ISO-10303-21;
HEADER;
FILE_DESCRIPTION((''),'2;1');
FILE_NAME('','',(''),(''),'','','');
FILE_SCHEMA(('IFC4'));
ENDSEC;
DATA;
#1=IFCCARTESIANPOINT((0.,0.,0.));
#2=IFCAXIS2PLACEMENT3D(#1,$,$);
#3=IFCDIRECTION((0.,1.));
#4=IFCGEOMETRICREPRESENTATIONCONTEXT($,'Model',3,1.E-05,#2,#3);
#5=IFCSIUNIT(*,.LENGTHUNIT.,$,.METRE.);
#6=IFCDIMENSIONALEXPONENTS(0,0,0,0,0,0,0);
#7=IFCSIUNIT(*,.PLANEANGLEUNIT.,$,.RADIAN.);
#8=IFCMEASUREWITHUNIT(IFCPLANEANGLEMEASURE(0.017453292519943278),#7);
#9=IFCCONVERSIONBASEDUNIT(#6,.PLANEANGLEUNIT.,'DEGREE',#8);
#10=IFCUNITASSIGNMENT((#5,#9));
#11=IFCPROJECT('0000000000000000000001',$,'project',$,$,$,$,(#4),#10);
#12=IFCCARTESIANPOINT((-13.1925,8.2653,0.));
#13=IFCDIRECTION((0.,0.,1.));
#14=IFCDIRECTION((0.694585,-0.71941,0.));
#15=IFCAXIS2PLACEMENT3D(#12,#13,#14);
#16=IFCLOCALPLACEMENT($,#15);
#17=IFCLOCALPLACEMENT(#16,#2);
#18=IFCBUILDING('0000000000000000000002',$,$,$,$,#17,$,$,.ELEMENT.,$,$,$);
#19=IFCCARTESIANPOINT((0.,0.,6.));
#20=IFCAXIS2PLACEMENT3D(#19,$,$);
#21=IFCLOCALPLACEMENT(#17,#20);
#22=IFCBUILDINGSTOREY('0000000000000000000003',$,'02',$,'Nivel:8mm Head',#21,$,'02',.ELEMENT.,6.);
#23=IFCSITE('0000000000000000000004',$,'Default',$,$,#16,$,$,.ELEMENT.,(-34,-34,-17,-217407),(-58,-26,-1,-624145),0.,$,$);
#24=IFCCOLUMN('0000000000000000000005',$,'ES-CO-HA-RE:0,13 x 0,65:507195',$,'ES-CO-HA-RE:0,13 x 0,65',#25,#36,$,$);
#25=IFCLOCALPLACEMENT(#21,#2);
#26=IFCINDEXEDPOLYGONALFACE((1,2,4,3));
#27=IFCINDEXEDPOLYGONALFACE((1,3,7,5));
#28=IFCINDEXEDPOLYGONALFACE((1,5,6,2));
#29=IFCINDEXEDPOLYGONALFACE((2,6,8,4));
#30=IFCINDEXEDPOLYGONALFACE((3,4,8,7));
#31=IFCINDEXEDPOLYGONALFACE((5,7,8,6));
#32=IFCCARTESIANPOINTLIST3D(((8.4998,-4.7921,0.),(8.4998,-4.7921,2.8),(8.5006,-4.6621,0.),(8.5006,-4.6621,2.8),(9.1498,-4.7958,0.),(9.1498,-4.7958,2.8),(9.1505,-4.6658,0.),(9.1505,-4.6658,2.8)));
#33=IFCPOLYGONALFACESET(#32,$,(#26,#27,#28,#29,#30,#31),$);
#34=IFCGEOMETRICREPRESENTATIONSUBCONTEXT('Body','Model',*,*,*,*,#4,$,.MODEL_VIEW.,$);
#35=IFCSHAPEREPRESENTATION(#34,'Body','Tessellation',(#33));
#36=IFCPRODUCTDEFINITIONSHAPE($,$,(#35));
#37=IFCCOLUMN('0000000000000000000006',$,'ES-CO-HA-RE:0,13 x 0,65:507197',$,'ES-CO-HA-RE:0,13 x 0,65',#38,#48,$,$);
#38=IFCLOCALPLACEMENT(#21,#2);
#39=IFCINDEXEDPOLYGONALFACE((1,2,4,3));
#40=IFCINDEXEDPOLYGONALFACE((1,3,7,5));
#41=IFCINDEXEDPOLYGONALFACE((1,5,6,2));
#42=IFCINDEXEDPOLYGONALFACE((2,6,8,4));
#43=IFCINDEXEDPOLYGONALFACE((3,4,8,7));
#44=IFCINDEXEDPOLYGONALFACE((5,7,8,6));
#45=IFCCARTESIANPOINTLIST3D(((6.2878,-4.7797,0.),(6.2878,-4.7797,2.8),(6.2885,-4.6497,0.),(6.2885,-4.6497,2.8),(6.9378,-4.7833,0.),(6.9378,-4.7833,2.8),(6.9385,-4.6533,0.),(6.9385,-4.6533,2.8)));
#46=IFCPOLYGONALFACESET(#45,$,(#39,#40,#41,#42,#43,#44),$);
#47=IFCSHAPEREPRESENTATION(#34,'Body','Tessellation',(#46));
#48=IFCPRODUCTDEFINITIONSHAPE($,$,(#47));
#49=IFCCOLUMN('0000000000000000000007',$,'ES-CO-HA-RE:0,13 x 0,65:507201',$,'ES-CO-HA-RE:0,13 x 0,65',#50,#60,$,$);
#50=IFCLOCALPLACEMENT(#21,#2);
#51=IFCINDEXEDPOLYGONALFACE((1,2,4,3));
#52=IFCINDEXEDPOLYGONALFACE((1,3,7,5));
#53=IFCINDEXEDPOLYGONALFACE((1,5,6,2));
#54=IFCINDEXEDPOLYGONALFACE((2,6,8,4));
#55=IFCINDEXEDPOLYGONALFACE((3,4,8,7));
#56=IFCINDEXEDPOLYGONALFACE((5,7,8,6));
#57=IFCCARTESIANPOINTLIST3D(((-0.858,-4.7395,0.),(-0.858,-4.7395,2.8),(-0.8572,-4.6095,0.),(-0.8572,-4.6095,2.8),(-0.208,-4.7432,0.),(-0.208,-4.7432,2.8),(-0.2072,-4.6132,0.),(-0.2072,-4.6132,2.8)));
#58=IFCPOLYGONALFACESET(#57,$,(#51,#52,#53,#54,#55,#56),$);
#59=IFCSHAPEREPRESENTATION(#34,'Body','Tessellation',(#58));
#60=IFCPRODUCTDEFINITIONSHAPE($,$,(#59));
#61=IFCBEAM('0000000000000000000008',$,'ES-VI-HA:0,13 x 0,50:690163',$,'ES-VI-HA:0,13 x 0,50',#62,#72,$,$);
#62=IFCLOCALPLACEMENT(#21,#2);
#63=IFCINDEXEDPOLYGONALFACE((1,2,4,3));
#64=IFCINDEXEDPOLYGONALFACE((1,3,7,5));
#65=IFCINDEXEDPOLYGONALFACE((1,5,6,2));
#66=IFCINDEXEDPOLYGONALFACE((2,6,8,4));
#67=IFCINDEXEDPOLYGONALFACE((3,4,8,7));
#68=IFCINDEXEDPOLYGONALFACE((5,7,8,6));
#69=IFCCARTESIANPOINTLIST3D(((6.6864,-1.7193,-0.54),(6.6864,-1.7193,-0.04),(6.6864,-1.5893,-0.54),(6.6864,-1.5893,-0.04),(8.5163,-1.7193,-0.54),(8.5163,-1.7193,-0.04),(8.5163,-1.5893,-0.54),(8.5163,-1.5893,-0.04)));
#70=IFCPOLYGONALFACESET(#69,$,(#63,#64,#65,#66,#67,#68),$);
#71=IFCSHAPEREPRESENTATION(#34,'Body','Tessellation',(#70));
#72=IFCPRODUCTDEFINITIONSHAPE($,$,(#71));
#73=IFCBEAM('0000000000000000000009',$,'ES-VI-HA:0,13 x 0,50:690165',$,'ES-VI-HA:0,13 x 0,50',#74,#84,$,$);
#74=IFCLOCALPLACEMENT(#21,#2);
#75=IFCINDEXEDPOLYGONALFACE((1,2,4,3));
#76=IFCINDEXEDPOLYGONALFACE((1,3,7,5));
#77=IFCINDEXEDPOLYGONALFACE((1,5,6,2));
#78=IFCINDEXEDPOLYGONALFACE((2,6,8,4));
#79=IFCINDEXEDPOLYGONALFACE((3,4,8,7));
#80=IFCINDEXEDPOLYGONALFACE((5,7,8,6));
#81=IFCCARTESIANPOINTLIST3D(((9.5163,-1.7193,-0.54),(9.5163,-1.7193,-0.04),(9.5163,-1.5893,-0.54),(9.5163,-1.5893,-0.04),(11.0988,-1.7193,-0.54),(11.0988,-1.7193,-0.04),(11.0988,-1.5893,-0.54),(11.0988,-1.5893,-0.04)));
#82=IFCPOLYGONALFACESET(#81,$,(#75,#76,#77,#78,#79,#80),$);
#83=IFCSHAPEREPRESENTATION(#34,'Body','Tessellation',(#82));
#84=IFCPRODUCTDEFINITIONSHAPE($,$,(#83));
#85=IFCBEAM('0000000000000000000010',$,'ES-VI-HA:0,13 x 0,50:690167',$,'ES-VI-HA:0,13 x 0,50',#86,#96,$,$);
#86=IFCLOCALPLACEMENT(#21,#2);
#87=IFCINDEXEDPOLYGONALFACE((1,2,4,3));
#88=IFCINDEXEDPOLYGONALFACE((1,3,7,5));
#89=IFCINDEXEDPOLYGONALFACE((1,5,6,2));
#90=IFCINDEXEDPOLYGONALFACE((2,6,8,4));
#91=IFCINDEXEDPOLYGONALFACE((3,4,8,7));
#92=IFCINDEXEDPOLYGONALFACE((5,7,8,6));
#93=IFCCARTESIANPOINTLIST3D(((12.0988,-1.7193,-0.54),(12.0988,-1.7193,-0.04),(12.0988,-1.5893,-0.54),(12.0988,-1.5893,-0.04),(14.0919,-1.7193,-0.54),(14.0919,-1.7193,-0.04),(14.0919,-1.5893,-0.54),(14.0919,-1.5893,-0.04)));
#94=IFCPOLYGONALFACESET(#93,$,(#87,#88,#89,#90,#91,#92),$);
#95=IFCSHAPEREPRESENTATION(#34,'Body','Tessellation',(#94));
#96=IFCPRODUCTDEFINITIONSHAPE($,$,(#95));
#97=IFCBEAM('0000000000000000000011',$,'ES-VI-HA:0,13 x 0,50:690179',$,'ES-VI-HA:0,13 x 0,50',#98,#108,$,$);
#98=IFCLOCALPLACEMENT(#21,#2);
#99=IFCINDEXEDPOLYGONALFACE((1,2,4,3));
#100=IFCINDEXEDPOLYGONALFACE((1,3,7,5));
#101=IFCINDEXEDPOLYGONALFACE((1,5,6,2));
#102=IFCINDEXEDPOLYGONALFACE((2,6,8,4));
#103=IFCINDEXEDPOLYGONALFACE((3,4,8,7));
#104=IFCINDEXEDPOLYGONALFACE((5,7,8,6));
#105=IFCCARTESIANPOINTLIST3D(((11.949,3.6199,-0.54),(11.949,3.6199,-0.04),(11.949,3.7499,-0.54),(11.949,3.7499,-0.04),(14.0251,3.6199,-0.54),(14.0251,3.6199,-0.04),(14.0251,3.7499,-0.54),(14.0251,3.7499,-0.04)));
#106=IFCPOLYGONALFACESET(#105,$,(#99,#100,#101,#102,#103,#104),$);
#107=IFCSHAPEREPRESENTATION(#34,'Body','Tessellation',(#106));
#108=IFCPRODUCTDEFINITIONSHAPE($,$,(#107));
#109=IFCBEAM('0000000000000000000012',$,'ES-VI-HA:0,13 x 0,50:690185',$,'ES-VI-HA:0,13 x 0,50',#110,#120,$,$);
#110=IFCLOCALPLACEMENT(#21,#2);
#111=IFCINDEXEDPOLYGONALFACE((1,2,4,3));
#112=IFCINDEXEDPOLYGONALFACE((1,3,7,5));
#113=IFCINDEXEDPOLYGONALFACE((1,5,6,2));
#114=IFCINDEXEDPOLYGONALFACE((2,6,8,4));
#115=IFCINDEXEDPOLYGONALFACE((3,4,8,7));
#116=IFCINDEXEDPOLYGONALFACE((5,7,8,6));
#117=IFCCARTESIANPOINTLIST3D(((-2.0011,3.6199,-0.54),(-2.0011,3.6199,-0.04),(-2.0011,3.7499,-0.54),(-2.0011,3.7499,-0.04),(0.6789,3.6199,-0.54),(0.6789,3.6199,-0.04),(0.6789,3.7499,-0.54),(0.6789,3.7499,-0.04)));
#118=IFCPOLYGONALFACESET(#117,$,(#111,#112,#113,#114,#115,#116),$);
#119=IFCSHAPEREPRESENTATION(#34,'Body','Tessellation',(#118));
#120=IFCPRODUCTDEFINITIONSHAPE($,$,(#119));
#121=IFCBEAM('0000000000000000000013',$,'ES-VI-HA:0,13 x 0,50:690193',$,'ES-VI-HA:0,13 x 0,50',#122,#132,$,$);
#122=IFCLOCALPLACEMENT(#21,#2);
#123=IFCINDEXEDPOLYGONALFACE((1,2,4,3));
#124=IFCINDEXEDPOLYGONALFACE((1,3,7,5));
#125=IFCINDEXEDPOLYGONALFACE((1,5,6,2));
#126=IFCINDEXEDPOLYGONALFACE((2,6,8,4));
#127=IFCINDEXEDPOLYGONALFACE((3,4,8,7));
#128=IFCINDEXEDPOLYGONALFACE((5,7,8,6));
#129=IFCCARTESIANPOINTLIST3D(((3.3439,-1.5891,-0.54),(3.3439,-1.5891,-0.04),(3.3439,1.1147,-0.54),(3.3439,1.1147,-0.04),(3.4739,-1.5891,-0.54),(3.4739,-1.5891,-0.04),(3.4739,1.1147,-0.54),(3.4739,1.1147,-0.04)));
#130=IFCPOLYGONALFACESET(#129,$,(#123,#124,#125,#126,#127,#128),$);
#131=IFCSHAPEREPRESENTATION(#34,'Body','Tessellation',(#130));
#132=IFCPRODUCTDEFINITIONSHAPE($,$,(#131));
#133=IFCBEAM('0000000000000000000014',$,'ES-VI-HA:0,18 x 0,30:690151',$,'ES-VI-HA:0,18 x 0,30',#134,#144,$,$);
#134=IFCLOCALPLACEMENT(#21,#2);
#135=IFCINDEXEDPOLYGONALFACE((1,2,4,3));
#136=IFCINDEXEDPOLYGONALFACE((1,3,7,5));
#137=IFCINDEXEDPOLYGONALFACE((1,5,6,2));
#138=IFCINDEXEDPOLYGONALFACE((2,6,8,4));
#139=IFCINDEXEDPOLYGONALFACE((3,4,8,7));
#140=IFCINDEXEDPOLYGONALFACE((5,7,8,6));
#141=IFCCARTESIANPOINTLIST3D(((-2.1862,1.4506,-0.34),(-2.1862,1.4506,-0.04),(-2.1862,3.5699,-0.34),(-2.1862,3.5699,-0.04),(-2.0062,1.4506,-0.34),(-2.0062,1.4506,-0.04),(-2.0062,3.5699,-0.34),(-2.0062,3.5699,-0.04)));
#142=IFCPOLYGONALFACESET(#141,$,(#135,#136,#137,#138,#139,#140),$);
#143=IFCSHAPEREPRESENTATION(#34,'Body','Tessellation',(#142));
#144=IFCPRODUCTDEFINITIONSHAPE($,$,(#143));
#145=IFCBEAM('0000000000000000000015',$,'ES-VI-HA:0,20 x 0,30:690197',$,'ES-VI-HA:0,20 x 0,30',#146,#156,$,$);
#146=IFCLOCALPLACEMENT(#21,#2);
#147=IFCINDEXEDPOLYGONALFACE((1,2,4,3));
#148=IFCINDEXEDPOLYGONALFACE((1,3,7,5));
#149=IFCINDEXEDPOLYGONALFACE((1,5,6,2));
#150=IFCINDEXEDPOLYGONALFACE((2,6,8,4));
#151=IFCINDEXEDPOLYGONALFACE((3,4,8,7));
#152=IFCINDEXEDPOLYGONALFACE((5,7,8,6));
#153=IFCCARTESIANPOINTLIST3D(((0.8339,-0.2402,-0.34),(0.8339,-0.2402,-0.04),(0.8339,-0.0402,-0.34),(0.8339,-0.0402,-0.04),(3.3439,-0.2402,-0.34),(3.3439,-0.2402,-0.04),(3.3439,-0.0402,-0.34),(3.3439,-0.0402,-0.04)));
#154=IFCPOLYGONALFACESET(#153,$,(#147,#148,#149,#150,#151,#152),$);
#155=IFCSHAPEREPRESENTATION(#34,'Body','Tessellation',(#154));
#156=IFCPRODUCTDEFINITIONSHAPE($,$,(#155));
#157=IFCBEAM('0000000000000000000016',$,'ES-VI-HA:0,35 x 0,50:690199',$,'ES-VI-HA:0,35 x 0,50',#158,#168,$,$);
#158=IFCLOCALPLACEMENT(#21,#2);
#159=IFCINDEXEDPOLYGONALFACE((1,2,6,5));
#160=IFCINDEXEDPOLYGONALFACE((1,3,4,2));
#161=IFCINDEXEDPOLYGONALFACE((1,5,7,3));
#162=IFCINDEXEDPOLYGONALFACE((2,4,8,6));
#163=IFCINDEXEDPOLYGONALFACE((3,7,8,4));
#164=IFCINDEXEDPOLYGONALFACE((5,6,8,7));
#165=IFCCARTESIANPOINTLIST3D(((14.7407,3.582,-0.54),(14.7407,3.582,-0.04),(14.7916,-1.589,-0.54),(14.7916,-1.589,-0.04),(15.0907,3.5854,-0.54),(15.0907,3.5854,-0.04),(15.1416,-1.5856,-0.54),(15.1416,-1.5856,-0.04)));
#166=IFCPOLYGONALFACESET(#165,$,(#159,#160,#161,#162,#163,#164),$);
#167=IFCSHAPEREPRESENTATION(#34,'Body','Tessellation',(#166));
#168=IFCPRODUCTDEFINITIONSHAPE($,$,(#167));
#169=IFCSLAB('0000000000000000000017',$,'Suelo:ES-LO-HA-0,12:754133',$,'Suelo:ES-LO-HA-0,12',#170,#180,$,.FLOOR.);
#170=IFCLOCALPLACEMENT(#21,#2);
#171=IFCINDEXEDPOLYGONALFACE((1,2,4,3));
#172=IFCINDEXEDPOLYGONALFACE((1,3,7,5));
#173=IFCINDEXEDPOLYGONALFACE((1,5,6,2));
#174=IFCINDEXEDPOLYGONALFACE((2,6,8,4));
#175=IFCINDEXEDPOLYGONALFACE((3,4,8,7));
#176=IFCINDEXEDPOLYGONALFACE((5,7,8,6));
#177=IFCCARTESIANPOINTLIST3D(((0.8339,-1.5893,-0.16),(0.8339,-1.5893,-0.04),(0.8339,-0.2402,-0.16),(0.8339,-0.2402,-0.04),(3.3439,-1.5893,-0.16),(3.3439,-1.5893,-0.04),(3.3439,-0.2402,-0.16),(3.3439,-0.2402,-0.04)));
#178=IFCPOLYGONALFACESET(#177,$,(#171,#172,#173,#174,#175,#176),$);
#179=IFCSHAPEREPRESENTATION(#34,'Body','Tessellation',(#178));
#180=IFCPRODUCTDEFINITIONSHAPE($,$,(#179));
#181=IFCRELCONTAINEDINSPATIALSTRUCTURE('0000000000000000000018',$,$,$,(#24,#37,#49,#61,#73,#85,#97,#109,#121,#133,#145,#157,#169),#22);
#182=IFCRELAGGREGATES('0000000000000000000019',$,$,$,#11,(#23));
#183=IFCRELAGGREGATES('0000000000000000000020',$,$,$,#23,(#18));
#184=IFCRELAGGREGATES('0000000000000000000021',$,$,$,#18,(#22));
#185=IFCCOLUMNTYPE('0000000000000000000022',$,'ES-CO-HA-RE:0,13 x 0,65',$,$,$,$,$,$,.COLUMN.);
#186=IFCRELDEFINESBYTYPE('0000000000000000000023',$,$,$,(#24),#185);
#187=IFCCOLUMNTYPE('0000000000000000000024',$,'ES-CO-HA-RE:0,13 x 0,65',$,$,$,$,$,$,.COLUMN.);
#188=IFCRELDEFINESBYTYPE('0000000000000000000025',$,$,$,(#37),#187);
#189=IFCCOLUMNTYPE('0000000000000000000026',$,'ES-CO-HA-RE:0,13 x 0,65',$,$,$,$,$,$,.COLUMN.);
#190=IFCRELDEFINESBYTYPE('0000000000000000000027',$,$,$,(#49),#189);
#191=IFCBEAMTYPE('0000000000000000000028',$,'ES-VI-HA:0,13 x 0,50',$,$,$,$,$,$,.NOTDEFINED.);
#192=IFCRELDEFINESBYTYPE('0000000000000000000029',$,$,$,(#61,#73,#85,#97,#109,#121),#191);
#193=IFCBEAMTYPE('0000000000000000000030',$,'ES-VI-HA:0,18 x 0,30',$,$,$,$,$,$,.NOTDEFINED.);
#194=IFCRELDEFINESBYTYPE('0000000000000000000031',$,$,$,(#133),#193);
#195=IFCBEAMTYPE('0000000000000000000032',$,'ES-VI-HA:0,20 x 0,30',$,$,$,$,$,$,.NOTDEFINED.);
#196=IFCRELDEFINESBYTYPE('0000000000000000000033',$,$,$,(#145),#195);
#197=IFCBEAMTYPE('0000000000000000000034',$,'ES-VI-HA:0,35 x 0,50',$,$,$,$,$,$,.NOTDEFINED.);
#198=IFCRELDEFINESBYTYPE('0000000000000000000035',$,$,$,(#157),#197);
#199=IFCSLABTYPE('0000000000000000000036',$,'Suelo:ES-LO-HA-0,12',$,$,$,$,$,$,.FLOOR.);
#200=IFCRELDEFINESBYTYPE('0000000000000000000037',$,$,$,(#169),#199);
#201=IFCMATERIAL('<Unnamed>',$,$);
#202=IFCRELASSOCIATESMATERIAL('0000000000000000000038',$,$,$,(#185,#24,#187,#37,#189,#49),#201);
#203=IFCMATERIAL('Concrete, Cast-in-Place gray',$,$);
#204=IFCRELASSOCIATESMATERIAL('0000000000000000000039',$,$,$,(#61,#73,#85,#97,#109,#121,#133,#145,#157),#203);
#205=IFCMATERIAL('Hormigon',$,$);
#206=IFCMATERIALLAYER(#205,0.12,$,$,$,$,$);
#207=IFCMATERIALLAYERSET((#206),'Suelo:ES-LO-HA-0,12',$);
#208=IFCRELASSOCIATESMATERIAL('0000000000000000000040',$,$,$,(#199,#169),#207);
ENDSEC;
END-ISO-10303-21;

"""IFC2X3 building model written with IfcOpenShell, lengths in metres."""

from ifc_helpers import new_model, entity, si_unit, converted_unit, direction, frame, frame_2d, origin, origin_2d_with_axis, place, context, subcontext, project, spatial, rectangle, extrude, source, transform, mapped, material, layer, layer_set, layer_usage, type_object, type_shapes, element, save


model = new_model("IFC2X3")

# Units and contexts
model_context = context("Model", 3, precision=1e-05, world=origin(), true_north=direction((0.0, 1.0)))
body_context = subcontext(model_context, "Body", "Model", "MODEL_VIEW")
ifc_project = project(units=[si_unit("LENGTHUNIT", "METRE"), converted_unit("PLANEANGLEUNIT", "DEGREE", entity("IfcPlaneAngleMeasure", 0.017453292519943278), si_unit("PLANEANGLEUNIT", "RADIAN"), dimensions=[0, 0, 0, 0, 0, 0, 0])], contexts=[model_context])

# Site, building, storey
site_placement = place(None, frame((-13.1925, 8.2653, 0.0), z_axis=(0.0, 0.0, 1.0), x_axis=(0.694585, -0.71941, 0.0)))
site = spatial("IfcSite", under=ifc_project, at=site_placement, Name="Default", CompositionType="ELEMENT", RefLatitude=(-34, -34, -17, -217407), RefLongitude=(-58, -26, -1, -624145), RefElevation=0.0)
building_placement = place(site_placement, origin())
building = spatial("IfcBuilding", under=site, at=building_placement, CompositionType="ELEMENT")
storey_placement = place(building_placement, frame((0.0, 0.0, 6.0)))
storey = spatial("IfcBuildingStorey", under=building, at=storey_placement, Name="02", ObjectType="Nivel:8mm Head", LongName="02", CompositionType="ELEMENT", Elevation=6.0)

# Columns
ifc_material_1 = material(Name="<Unnamed>")
column_type_1 = type_object("IfcColumnType", Name="ES-CO-HA-RE:0,13 x 0,65", PredefinedType="COLUMN", material=ifc_material_1)
shared_shape_1 = source(origin(), body_context, "Body", "SweptSolid", [
    extrude(rectangle(XDim=0.65, YDim=0.13, at=origin_2d_with_axis()), frame((8.8252, -4.7289, 6.0), z_axis=(0.0, 0.0, 1.0), x_axis=(-0.999984, 0.005619, 0.0)), (0.0, 0.0, 1.0), 2.8),
])
type_shapes(column_type_1, [shared_shape_1])
column_1_placement = place(storey_placement, frame((0.0, 0.0, -6.0)))
element("IfcColumn", 1, at=column_1_placement, inside=storey, type_object=column_type_1, material=ifc_material_1, Name="ES-CO-HA-RE:0,13 x 0,65:507195", ObjectType="ES-CO-HA-RE:0,13 x 0,65", context=body_context, shape_type="MappedRepresentation", body=[
    mapped(shared_shape_1, transform((0.0, 0.0, 0.0), scale=1.0)),
])
column_type_2 = type_object("IfcColumnType", Name="ES-CO-HA-RE:0,13 x 0,65", PredefinedType="COLUMN", material=ifc_material_1)
shared_shape_2 = source(origin(), body_context, "Body", "SweptSolid", [
    extrude(rectangle(XDim=0.65, YDim=0.13, at=frame_2d((0.0, 0.0), x_axis=(1.0, 0.0))), frame((6.6131, -4.7165, 6.0), z_axis=(0.0, 0.0, 1.0), x_axis=(-0.999984, 0.005619, 0.0)), (0.0, 0.0, 1.0), 2.8),
])
type_shapes(column_type_2, [shared_shape_2])
column_2_placement = place(storey_placement, frame((0.0, 0.0, -6.0)))
element("IfcColumn", 2, at=column_2_placement, inside=storey, type_object=column_type_2, material=ifc_material_1, Name="ES-CO-HA-RE:0,13 x 0,65:507197", ObjectType="ES-CO-HA-RE:0,13 x 0,65", context=body_context, shape_type="MappedRepresentation", body=[
    mapped(shared_shape_2, transform((0.0, 0.0, 0.0), scale=1.0)),
])
column_type_3 = type_object("IfcColumnType", Name="ES-CO-HA-RE:0,13 x 0,65", PredefinedType="COLUMN", material=ifc_material_1)
shared_shape_3 = source(origin(), body_context, "Body", "SweptSolid", [
    extrude(rectangle(XDim=0.65, YDim=0.13, at=frame_2d((0.0, 0.0), x_axis=(1.0, 0.0))), frame((-0.5326, -4.6764, 6.0), z_axis=(0.0, 0.0, 1.0), x_axis=(-0.999984, 0.005619, 0.0)), (0.0, 0.0, 1.0), 2.8),
])
type_shapes(column_type_3, [shared_shape_3])
column_3_placement = place(storey_placement, frame((0.0, 0.0, -6.0)))
element("IfcColumn", 3, at=column_3_placement, inside=storey, type_object=column_type_3, material=ifc_material_1, Name="ES-CO-HA-RE:0,13 x 0,65:507201", ObjectType="ES-CO-HA-RE:0,13 x 0,65", context=body_context, shape_type="MappedRepresentation", body=[
    mapped(shared_shape_3, transform((0.0, 0.0, 0.0), scale=1.0)),
])

# Beams
ifc_material_2 = material(Name="Concrete, Cast-in-Place gray")
beam_type_1 = type_object("IfcBeamType", Name="ES-VI-HA:0,13 x 0,50", PredefinedType="NOTDEFINED")
beam_1_placement = place(storey_placement, frame((5.7373, -1.6543, -0.04)))
element("IfcBeam", 4, at=beam_1_placement, inside=storey, type_object=beam_type_1, material=ifc_material_2, Name="ES-VI-HA:0,13 x 0,50:690163", ObjectType="ES-VI-HA:0,13 x 0,50", context=body_context, shape_type="SweptSolid", body=[
    extrude(rectangle(XDim=0.5, YDim=0.13, at=frame_2d((0.0, 0.0), x_axis=(1.0, 0.0))), frame((0.9491, 0.0, -0.25), z_axis=(1.0, 0.0, 0.0), x_axis=(0.0, 0.0, -1.0)), (0.0, 0.0, 1.0), 1.8299),
])
beam_2_placement = place(storey_placement, frame((8.3198, -1.6543, -0.04)))
element("IfcBeam", 5, at=beam_2_placement, inside=storey, type_object=beam_type_1, material=ifc_material_2, Name="ES-VI-HA:0,13 x 0,50:690165", ObjectType="ES-VI-HA:0,13 x 0,50", context=body_context, shape_type="SweptSolid", body=[
    extrude(rectangle(XDim=0.5, YDim=0.13, at=frame_2d((0.0, 0.0), x_axis=(1.0, 0.0))), frame((1.1965, 0.0, -0.25), z_axis=(1.0, 0.0, 0.0), x_axis=(0.0, 0.0, -1.0)), (0.0, 0.0, 1.0), 1.5825),
])
beam_3_placement = place(storey_placement, frame((11.3129, -1.6543, -0.04)))
element("IfcBeam", 6, at=beam_3_placement, inside=storey, type_object=beam_type_1, material=ifc_material_2, Name="ES-VI-HA:0,13 x 0,50:690167", ObjectType="ES-VI-HA:0,13 x 0,50", context=body_context, shape_type="SweptSolid", body=[
    extrude(rectangle(XDim=0.5, YDim=0.13, at=frame_2d((0.0, 0.0), x_axis=(1.0, 0.0))), frame((0.7858, 0.0, -0.25), z_axis=(1.0, 0.0, 0.0), x_axis=(0.0, 0.0, -1.0)), (0.0, 0.0, 1.0), 1.9932),
])
beam_4_placement = place(storey_placement, frame((11.624, 3.6849, -0.04)))
element("IfcBeam", 7, at=beam_4_placement, inside=storey, type_object=beam_type_1, material=ifc_material_2, Name="ES-VI-HA:0,13 x 0,50:690179", ObjectType="ES-VI-HA:0,13 x 0,50", context=body_context, shape_type="SweptSolid", body=[
    extrude(rectangle(XDim=0.5, YDim=0.13, at=frame_2d((0.0, 0.0), x_axis=(1.0, 0.0))), frame((0.325, 0.0, -0.25), z_axis=(1.0, 0.0, 0.0), x_axis=(0.0, 0.0, -1.0)), (0.0, 0.0, 1.0), 2.0761),
])
beam_5_placement = place(storey_placement, frame((-2.0011, 3.6849, -0.04)))
element("IfcBeam", 8, at=beam_5_placement, inside=storey, type_object=beam_type_1, material=ifc_material_2, Name="ES-VI-HA:0,13 x 0,50:690185", ObjectType="ES-VI-HA:0,13 x 0,50", context=body_context, shape_type="SweptSolid", body=[
    extrude(rectangle(XDim=0.5, YDim=0.13, at=frame_2d((0.0, 0.0), x_axis=(1.0, 0.0))), frame((0.0, 0.0, -0.25), z_axis=(1.0, 0.0, 0.0), x_axis=(0.0, 0.0, -1.0)), (0.0, 0.0, 1.0), 2.68),
])
beam_6_placement = place(storey_placement, frame((3.4089, -1.5891, -0.04), z_axis=(0.0, 0.0, 1.0), x_axis=(0.0, 1.0, 0.0)))
element("IfcBeam", 9, at=beam_6_placement, inside=storey, type_object=beam_type_1, material=ifc_material_2, Name="ES-VI-HA:0,13 x 0,50:690193", ObjectType="ES-VI-HA:0,13 x 0,50", context=body_context, shape_type="SweptSolid", body=[
    extrude(rectangle(XDim=0.5, YDim=0.13, at=origin_2d_with_axis()), frame((0.0, 0.0, -0.25), z_axis=(1.0, 0.0, 0.0), x_axis=(0.0, 0.0, -1.0)), (0.0, 0.0, 1.0), 2.7037),
])
beam_type_2 = type_object("IfcBeamType", Name="ES-VI-HA:0,18 x 0,30", PredefinedType="NOTDEFINED")
beam_7_placement = place(storey_placement, frame((-2.0962, 3.5699, -0.04), z_axis=(0.0, 0.0, 1.0), x_axis=(0.0, -1.0, 0.0)))
element("IfcBeam", 10, at=beam_7_placement, inside=storey, type_object=beam_type_2, material=ifc_material_2, Name="ES-VI-HA:0,18 x 0,30:690151", ObjectType="ES-VI-HA:0,18 x 0,30", context=body_context, shape_type="SweptSolid", body=[
    extrude(rectangle(XDim=0.3, YDim=0.18, at=origin_2d_with_axis()), frame((0.0, 0.0, -0.15), z_axis=(1.0, 0.0, 0.0), x_axis=(0.0, 0.0, -1.0)), (0.0, 0.0, 1.0), 2.1193),
])
beam_type_3 = type_object("IfcBeamType", Name="ES-VI-HA:0,20 x 0,30", PredefinedType="NOTDEFINED")
beam_8_placement = place(storey_placement, frame((0.7589, -0.1402, -0.04)))
element("IfcBeam", 11, at=beam_8_placement, inside=storey, type_object=beam_type_3, material=ifc_material_2, Name="ES-VI-HA:0,20 x 0,30:690197", ObjectType="ES-VI-HA:0,20 x 0,30", context=body_context, shape_type="SweptSolid", body=[
    extrude(rectangle(XDim=0.3, YDim=0.2, at=frame_2d((0.0, 0.0), x_axis=(1.0, 0.0))), frame((0.075, 0.0, -0.15), z_axis=(1.0, 0.0, 0.0), x_axis=(0.0, 0.0, -1.0)), (0.0, 0.0, 1.0), 2.51),
])
beam_type_4 = type_object("IfcBeamType", Name="ES-VI-HA:0,35 x 0,50", PredefinedType="NOTDEFINED")
beam_9_placement = place(storey_placement, frame((14.9158, 3.5724, -0.04), z_axis=(0.0, 0.0, 1.0), x_axis=(0.009844, -0.999952, 0.0)))
element("IfcBeam", 12, at=beam_9_placement, inside=storey, type_object=beam_type_4, material=ifc_material_2, Name="ES-VI-HA:0,35 x 0,50:690199", ObjectType="ES-VI-HA:0,35 x 0,50", context=body_context, shape_type="SweptSolid", body=[
    extrude(rectangle(XDim=0.5, YDim=0.35, at=frame_2d((0.0, 0.0), x_axis=(1.0, 0.0))), frame((-0.0113, 0.0, -0.25), z_axis=(1.0, 0.0, 0.0), x_axis=(0.0, 0.0, -1.0)), (0.0, 0.0, 1.0), 5.1713),
])

# Shared definitions
ifc_material_3 = material(Name="Hormigon")

# Slab
ifc_layer_1 = layer(ifc_material_3, 0.12)
ifc_layer_set_1 = layer_set([ifc_layer_1], Name="Suelo:ES-LO-HA-0,12")
ifc_layer_usage_1 = layer_usage(ifc_layer_set_1, "AXIS3", "POSITIVE", 0.0)
slab_type_1 = type_object("IfcSlabType", Name="Suelo:ES-LO-HA-0,12", PredefinedType="FLOOR", material=ifc_layer_set_1)
slab_1_placement = place(storey_placement, origin())
element("IfcSlab", 13, at=slab_1_placement, inside=storey, type_object=slab_type_1, material=ifc_layer_usage_1, Name="Suelo:ES-LO-HA-0,12:754133", ObjectType="Suelo:ES-LO-HA-0,12", PredefinedType="FLOOR", context=body_context, shape_type="SweptSolid", body=[
    extrude(rectangle(XDim=1.3491, YDim=2.51, at=origin_2d_with_axis()), frame((2.0889, -0.9147, -0.04), z_axis=(0.0, 0.0, -1.0), x_axis=(0.0, 1.0, 0.0)), (0.0, 0.0, 1.0), 0.12),
])

save(model, "model.ifc")
